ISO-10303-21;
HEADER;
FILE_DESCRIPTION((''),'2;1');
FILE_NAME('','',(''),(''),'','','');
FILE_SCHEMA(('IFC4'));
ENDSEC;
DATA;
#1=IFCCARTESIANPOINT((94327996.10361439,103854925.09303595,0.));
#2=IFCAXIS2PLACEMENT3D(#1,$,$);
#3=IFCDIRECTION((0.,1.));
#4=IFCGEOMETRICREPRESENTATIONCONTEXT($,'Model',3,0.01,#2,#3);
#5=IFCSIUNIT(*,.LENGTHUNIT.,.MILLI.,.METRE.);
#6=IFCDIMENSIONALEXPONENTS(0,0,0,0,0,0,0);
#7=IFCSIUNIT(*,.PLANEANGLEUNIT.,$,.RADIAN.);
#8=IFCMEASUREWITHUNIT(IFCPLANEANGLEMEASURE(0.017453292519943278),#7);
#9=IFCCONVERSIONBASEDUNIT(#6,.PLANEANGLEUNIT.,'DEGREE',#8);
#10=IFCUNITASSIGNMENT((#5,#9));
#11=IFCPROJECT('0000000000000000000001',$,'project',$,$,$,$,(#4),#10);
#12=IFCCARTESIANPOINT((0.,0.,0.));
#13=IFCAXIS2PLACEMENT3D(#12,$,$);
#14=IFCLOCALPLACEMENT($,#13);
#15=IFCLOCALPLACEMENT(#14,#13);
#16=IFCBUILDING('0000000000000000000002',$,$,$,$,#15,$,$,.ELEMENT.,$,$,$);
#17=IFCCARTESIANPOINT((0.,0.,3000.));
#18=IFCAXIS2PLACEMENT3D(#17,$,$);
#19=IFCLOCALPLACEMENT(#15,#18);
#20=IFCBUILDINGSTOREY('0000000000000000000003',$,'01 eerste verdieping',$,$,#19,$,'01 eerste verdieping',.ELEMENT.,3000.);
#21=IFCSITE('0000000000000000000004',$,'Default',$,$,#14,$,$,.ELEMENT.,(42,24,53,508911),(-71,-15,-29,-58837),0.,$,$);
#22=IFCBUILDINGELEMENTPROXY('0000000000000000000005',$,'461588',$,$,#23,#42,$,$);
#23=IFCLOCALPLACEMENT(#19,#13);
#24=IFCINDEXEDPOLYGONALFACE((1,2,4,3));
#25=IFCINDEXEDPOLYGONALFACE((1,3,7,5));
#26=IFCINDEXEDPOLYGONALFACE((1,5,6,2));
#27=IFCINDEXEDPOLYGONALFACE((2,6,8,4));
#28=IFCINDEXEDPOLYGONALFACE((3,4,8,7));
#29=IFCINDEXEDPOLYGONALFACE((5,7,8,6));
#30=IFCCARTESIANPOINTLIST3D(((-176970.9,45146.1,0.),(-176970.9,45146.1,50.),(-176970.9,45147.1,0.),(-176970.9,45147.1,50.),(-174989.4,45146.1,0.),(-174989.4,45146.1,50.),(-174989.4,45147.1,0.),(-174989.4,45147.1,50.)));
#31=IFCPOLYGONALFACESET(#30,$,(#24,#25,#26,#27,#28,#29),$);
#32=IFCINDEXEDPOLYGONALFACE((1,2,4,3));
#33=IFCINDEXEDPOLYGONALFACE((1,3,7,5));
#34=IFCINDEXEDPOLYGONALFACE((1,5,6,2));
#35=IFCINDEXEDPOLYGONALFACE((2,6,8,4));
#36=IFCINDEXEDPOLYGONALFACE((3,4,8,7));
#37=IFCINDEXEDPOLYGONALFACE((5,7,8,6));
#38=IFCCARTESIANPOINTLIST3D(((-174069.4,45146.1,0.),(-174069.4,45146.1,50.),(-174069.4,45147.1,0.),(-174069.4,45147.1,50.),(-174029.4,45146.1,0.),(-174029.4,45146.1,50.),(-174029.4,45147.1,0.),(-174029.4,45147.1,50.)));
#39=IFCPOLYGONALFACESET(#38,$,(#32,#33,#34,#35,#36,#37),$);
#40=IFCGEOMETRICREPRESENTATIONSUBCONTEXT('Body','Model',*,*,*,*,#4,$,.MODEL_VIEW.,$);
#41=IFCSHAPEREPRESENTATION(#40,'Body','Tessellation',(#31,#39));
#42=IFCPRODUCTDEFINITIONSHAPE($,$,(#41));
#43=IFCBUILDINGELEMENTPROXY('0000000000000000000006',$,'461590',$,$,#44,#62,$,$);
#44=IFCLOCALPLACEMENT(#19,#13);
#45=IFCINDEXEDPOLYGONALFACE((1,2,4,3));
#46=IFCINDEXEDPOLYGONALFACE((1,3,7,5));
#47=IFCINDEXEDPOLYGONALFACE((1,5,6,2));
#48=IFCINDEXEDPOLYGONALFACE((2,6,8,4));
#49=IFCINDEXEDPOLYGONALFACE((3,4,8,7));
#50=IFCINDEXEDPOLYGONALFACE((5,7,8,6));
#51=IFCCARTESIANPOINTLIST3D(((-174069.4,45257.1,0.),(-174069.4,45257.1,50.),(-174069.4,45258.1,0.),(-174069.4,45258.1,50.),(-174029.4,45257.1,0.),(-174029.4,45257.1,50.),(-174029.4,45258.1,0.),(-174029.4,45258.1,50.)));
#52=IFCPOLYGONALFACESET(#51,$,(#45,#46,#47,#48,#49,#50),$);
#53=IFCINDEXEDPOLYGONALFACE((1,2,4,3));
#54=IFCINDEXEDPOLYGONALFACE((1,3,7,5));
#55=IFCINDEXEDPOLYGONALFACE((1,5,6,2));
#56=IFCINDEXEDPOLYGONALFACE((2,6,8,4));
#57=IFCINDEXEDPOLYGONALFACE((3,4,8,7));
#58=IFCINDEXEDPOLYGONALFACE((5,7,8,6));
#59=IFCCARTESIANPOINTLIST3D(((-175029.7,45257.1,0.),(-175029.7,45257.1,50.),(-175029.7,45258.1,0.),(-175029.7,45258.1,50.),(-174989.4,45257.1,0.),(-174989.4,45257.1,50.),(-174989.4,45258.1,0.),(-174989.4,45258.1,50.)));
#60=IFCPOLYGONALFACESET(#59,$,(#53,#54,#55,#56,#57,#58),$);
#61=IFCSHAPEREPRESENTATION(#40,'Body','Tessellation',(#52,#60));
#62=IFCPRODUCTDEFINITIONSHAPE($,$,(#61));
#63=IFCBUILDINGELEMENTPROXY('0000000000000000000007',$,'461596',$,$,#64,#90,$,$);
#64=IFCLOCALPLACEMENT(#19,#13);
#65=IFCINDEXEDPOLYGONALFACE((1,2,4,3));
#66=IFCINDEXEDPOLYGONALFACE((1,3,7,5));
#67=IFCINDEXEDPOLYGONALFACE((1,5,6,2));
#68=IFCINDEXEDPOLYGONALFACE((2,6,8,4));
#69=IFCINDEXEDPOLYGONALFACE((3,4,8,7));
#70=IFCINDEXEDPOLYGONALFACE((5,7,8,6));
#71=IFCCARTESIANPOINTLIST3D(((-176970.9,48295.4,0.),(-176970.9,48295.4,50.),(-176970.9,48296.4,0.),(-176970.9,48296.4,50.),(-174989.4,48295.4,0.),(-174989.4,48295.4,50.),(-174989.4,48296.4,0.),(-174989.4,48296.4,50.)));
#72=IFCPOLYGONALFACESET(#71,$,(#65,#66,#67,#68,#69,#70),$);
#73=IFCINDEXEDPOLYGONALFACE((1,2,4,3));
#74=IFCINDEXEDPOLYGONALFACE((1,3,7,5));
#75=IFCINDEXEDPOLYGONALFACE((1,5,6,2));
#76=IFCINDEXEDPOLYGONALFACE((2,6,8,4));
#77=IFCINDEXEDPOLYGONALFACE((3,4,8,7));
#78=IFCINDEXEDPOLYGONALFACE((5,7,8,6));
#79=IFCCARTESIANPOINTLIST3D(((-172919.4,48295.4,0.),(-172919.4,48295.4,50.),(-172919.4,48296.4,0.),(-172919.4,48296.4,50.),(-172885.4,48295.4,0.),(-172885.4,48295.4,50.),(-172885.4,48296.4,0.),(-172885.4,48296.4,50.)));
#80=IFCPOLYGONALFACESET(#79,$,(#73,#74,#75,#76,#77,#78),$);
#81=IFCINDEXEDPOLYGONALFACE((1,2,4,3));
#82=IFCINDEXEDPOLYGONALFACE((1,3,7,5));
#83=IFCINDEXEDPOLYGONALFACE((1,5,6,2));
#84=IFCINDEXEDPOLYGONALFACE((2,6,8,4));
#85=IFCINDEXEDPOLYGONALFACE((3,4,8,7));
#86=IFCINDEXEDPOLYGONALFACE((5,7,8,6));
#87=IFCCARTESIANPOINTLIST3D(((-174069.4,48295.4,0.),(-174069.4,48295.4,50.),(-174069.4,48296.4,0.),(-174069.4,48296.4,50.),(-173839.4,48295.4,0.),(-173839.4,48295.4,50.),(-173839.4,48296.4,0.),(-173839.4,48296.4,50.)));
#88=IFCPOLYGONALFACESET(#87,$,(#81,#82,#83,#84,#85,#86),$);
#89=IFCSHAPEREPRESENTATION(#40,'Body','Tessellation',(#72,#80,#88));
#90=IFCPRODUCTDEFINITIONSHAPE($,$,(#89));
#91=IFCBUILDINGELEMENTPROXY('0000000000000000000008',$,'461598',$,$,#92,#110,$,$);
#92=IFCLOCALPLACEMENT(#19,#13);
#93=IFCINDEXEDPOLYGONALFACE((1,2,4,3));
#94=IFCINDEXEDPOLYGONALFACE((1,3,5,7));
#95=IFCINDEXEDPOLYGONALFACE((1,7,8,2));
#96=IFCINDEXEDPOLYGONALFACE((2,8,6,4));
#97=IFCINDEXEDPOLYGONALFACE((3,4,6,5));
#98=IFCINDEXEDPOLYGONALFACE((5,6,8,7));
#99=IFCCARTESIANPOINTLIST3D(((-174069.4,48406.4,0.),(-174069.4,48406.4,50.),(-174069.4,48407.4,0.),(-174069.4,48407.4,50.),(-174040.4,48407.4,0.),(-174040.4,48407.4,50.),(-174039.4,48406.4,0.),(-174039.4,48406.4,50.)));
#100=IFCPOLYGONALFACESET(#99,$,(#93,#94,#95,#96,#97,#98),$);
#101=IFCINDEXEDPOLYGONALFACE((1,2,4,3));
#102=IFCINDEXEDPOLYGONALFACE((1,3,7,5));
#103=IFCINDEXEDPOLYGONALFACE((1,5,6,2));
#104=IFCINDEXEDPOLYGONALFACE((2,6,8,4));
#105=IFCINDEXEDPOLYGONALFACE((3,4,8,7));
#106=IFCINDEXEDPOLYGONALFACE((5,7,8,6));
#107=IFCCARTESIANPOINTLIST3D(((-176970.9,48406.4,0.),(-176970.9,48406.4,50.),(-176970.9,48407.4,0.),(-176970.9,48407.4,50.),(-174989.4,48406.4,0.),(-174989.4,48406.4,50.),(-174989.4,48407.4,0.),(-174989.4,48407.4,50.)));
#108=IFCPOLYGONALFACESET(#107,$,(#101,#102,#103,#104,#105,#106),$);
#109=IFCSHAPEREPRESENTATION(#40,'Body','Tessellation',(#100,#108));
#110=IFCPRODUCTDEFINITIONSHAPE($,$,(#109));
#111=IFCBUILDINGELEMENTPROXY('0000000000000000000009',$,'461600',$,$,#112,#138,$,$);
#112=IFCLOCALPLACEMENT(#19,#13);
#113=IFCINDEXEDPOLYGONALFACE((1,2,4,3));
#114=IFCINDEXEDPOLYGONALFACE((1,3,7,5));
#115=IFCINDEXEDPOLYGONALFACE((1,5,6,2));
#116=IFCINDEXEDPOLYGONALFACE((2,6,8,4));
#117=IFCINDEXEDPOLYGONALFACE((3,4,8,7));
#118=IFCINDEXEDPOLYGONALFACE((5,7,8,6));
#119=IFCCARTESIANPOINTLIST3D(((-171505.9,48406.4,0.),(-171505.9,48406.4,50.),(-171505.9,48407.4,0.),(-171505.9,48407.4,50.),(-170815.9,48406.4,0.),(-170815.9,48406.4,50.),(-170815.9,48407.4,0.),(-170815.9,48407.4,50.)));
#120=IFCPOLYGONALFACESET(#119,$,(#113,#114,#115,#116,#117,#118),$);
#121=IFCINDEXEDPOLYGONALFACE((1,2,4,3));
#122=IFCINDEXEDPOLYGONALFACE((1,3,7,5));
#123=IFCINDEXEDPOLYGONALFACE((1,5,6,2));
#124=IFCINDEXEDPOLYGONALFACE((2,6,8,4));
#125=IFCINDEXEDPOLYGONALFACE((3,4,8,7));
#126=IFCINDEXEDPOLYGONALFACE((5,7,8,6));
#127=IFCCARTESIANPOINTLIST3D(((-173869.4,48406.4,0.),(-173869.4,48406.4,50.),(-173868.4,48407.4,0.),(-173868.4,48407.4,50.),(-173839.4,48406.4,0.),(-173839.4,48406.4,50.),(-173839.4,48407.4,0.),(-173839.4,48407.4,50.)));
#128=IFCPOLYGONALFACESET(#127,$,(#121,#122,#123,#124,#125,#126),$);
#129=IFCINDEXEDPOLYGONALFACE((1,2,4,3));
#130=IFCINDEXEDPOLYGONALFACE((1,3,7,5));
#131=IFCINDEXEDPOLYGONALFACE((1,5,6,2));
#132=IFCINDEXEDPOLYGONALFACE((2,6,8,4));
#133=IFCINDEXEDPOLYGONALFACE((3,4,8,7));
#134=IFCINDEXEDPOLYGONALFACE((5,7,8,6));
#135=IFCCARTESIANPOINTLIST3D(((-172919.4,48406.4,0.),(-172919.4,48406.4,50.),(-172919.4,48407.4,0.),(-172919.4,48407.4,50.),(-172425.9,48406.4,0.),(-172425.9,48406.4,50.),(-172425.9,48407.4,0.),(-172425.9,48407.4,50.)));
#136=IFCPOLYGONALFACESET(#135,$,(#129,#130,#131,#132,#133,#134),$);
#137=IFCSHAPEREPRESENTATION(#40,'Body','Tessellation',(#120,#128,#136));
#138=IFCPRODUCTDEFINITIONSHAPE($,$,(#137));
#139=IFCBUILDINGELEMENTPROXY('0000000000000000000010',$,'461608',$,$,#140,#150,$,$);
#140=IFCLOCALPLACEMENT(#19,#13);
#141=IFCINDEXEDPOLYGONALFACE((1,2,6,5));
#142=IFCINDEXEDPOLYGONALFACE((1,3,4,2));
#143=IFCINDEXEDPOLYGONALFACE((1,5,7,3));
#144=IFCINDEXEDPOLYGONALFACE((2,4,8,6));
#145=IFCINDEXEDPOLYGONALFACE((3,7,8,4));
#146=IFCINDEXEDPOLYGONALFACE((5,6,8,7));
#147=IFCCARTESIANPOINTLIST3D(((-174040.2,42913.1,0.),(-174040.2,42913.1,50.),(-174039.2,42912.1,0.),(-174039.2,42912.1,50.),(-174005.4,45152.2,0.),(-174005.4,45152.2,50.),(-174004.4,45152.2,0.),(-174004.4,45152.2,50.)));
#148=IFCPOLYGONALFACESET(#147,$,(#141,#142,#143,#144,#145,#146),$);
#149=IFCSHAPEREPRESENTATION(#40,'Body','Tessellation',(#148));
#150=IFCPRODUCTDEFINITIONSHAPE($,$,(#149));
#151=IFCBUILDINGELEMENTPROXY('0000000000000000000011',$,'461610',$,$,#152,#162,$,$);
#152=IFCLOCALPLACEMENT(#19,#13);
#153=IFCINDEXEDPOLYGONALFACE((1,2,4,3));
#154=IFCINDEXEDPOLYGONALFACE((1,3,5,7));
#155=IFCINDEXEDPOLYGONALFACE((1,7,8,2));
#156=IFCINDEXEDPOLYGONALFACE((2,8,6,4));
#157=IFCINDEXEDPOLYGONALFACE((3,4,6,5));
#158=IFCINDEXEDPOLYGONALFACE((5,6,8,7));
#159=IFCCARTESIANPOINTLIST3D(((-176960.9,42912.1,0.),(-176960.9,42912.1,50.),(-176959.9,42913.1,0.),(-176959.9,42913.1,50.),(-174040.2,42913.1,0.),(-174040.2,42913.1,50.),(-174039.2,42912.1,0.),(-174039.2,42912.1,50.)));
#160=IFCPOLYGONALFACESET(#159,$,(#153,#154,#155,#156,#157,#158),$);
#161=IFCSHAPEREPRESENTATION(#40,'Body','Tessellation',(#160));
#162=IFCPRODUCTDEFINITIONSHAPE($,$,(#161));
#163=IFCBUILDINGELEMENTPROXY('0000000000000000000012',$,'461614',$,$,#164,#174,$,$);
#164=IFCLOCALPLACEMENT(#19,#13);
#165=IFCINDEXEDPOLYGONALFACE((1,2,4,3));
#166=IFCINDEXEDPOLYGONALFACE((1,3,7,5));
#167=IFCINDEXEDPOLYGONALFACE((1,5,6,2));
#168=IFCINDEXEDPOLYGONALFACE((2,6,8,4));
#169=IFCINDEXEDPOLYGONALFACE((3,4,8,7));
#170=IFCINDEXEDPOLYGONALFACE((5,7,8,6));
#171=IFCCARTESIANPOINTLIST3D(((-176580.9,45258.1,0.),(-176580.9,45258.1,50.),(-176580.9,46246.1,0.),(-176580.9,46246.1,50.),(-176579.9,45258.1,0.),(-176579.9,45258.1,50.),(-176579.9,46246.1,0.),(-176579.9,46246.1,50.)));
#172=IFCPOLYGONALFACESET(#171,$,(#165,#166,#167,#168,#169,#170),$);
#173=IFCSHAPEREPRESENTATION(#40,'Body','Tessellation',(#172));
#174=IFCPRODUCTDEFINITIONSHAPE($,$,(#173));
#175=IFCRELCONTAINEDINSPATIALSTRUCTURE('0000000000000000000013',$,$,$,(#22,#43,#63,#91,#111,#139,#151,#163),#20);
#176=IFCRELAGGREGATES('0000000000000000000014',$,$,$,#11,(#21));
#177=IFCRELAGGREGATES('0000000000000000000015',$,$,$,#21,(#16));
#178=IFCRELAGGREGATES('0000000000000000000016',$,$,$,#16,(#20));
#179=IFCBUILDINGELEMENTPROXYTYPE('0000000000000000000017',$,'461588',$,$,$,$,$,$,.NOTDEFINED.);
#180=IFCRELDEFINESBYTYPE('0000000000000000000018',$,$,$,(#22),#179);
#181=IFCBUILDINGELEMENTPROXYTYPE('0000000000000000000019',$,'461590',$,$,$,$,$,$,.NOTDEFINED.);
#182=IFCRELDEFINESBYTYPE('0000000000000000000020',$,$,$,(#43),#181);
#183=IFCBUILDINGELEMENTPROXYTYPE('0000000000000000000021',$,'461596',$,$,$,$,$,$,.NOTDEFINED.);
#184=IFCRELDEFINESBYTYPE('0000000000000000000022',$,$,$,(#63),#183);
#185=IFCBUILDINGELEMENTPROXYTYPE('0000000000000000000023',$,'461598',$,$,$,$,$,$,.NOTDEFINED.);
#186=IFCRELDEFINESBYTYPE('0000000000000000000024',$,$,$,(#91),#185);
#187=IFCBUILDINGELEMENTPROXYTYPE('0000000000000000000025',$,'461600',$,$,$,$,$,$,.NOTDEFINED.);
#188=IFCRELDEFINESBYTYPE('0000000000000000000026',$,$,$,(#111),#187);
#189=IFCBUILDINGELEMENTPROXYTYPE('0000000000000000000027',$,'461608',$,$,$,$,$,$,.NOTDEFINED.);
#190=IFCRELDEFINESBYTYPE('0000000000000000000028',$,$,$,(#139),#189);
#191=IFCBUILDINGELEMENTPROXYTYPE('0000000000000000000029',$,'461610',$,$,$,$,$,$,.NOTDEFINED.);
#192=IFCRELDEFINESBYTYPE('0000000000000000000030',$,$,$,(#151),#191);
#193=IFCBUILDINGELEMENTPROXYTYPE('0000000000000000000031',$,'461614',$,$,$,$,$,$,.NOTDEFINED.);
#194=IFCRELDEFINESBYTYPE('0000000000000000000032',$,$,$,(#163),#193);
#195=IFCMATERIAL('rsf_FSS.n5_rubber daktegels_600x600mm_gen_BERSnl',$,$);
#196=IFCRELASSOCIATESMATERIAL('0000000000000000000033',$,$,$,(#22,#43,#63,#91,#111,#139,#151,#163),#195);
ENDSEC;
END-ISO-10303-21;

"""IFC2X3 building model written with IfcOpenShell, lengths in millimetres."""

from ifc_helpers import new_model, entity, si_unit, converted_unit, direction, frame, frame_2d, origin, origin_2d_with_axis, place, context, subcontext, project, spatial, polyline, rectangle, outline, extrude, material, type_object, element, save


model = new_model("IFC2X3")

# Units and contexts
model_context = context("Model", 3, precision=0.01, world=frame((94327996.10361439, 103854925.09303595, 0.0)), true_north=direction((0.0, 1.0)))
body_context = subcontext(model_context, "Body", "Model", "MODEL_VIEW")
ifc_project = project(units=[si_unit("LENGTHUNIT", "METRE", prefix="MILLI"), converted_unit("PLANEANGLEUNIT", "DEGREE", entity("IfcPlaneAngleMeasure", 0.017453292519943278), si_unit("PLANEANGLEUNIT", "RADIAN"), dimensions=[0, 0, 0, 0, 0, 0, 0])], contexts=[model_context])

# Site, building, storey
site_placement = place(None, origin())
site = spatial("IfcSite", under=ifc_project, at=site_placement, Name="Default", CompositionType="ELEMENT", RefLatitude=(42, 24, 53, 508911), RefLongitude=(-71, -15, -29, -58837), RefElevation=0.0)
building_placement = place(site_placement, origin())
building = spatial("IfcBuilding", under=site, at=building_placement, CompositionType="ELEMENT")
storey_placement = place(building_placement, frame((0.0, 0.0, 3000.0)))
storey = spatial("IfcBuildingStorey", under=building, at=storey_placement, Name="01 eerste verdieping", LongName="01 eerste verdieping", CompositionType="ELEMENT", Elevation=3000.0)

# Building element proxies
ifc_material = material(Name="rsf_FSS.n5_rubber daktegels_600x600mm_gen_BERSnl")
building_element_proxy_type_1 = type_object("IfcBuildingElementProxyType", Name="461588", PredefinedType="NOTDEFINED")
proxy_1_placement = place(storey_placement, origin())
element("IfcBuildingElementProxy", 1, at=proxy_1_placement, inside=storey, type_object=building_element_proxy_type_1, material=ifc_material, Name="461588", context=body_context, shape_type="SweptSolid", body=[
    extrude(rectangle(XDim=1981.5, YDim=1.0, at=frame_2d((0.0, 0.0), x_axis=(1.0, 0.0))), frame((-175980.1, 45146.6, 0.0)), (0.0, 0.0, 1.0), 50.0),
    extrude(rectangle(XDim=40.0, YDim=1.0, at=frame_2d((0.0, 0.0), x_axis=(1.0, 0.0))), frame((-174049.4, 45146.6, 0.0)), (0.0, 0.0, 1.0), 50.0),
])
building_element_proxy_type_2 = type_object("IfcBuildingElementProxyType", Name="461590", PredefinedType="NOTDEFINED")
proxy_2_placement = place(storey_placement, origin())
element("IfcBuildingElementProxy", 2, at=proxy_2_placement, inside=storey, type_object=building_element_proxy_type_2, material=ifc_material, Name="461590", context=body_context, shape_type="SweptSolid", body=[
    extrude(rectangle(XDim=40.0, YDim=1.0, at=frame_2d((0.0, 0.0), x_axis=(1.0, 0.0))), frame((-174049.4, 45257.6, 0.0), z_axis=(0.0, 0.0, 1.0), x_axis=(-1.0, 0.0, 0.0)), (0.0, 0.0, 1.0), 50.0),
    extrude(rectangle(XDim=40.4, YDim=1.0, at=origin_2d_with_axis()), frame((-175009.6, 45257.6, 0.0), z_axis=(0.0, 0.0, 1.0), x_axis=(-1.0, 0.0, 0.0)), (0.0, 0.0, 1.0), 50.0),
])
building_element_proxy_type_3 = type_object("IfcBuildingElementProxyType", Name="461596", PredefinedType="NOTDEFINED")
proxy_3_placement = place(storey_placement, origin())
element("IfcBuildingElementProxy", 3, at=proxy_3_placement, inside=storey, type_object=building_element_proxy_type_3, material=ifc_material, Name="461596", context=body_context, shape_type="SweptSolid", body=[
    extrude(rectangle(XDim=1981.5, YDim=1.0, at=frame_2d((0.0, 0.0), x_axis=(1.0, 0.0))), frame((-175980.1, 48295.9, 0.0)), (0.0, 0.0, 1.0), 50.0),
    extrude(rectangle(XDim=34.0, YDim=1.0, at=frame_2d((0.0, 0.0), x_axis=(1.0, 0.0))), frame((-172902.4, 48295.9, 0.0)), (0.0, 0.0, 1.0), 50.0),
    extrude(rectangle(XDim=230.0, YDim=1.0, at=frame_2d((0.0, 0.0), x_axis=(1.0, 0.0))), frame((-173954.4, 48295.9, 0.0)), (0.0, 0.0, 1.0), 50.0),
])
building_element_proxy_type_4 = type_object("IfcBuildingElementProxyType", Name="461598", PredefinedType="NOTDEFINED")
proxy_4_placement = place(storey_placement, origin())
element("IfcBuildingElementProxy", 4, at=proxy_4_placement, inside=storey, type_object=building_element_proxy_type_4, material=ifc_material, Name="461598", context=body_context, shape_type="SweptSolid", body=[
    extrude(outline(polyline([(-14.3, -0.5), (14.8, -0.5), (14.8, 0.5), (-15.3, 0.5), (-14.3, -0.5)])), frame((-174054.6, 48406.9, 0.0), z_axis=(0.0, 0.0, 1.0), x_axis=(-1.0, 0.0, 0.0)), (0.0, 0.0, 1.0), 50.0),
    extrude(rectangle(XDim=1981.5, YDim=1.0, at=frame_2d((0.0, 0.0), x_axis=(1.0, 0.0))), frame((-175980.1, 48406.9, 0.0), z_axis=(0.0, 0.0, 1.0), x_axis=(-1.0, 0.0, 0.0)), (0.0, 0.0, 1.0), 50.0),
])
building_element_proxy_type_5 = type_object("IfcBuildingElementProxyType", Name="461600", PredefinedType="NOTDEFINED")
proxy_5_placement = place(storey_placement, origin())
element("IfcBuildingElementProxy", 5, at=proxy_5_placement, inside=storey, type_object=building_element_proxy_type_5, material=ifc_material, Name="461600", context=body_context, shape_type="SweptSolid", body=[
    extrude(rectangle(XDim=690.0, YDim=1.0, at=origin_2d_with_axis()), frame((-171160.9, 48406.9, 0.0), z_axis=(0.0, 0.0, 1.0), x_axis=(-1.0, 0.0, 0.0)), (0.0, 0.0, 1.0), 50.0),
    extrude(outline(polyline([(-14.7, -0.5), (14.2, -0.5), (15.2, 0.5), (-14.7, 0.5), (-14.7, -0.5)])), frame((-173854.1, 48406.9, 0.0), z_axis=(0.0, 0.0, 1.0), x_axis=(-1.0, 0.0, 0.0)), (0.0, 0.0, 1.0), 50.0),
    extrude(rectangle(XDim=493.5, YDim=1.0, at=origin_2d_with_axis()), frame((-172672.6, 48406.9, 0.0), z_axis=(0.0, 0.0, 1.0), x_axis=(-1.0, 0.0, 0.0)), (0.0, 0.0, 1.0), 50.0),
])
building_element_proxy_type_6 = type_object("IfcBuildingElementProxyType", Name="461608", PredefinedType="NOTDEFINED")
proxy_6_placement = place(storey_placement, origin())
element("IfcBuildingElementProxy", 6, at=proxy_6_placement, inside=storey, type_object=building_element_proxy_type_6, material=ifc_material, Name="461608", context=body_context, shape_type="SweptSolid", body=[
    extrude(outline(polyline([(-1120.0, -0.5), (1119.5, -0.5), (1120.5, 0.5), (-1120.0, 0.5), (-1120.0, -0.5)])), frame((-174022.3, 44032.4, 0.0), z_axis=(0.0, 0.0, 1.0), x_axis=(-0.015554, -0.999879, 0.0)), (0.0, 0.0, 1.0), 50.0),
])
building_element_proxy_type_7 = type_object("IfcBuildingElementProxyType", Name="461610", PredefinedType="NOTDEFINED")
proxy_7_placement = place(storey_placement, origin())
element("IfcBuildingElementProxy", 7, at=proxy_7_placement, inside=storey, type_object=building_element_proxy_type_7, material=ifc_material, Name="461610", context=body_context, shape_type="SweptSolid", body=[
    extrude(outline(polyline([(-1459.8, -0.5), (1459.8, -0.5), (1460.8, 0.5), (-1460.8, 0.5), (-1459.8, -0.5)])), frame((-175500.0, 42912.6, 0.0), z_axis=(0.0, 0.0, 1.0), x_axis=(-1.0, 0.0, 0.0)), (0.0, 0.0, 1.0), 50.0),
])
building_element_proxy_type_8 = type_object("IfcBuildingElementProxyType", Name="461614", PredefinedType="NOTDEFINED")
proxy_8_placement = place(storey_placement, origin())
element("IfcBuildingElementProxy", 8, at=proxy_8_placement, inside=storey, type_object=building_element_proxy_type_8, material=ifc_material, Name="461614", context=body_context, shape_type="SweptSolid", body=[
    extrude(rectangle(XDim=988.0, YDim=1.0, at=frame_2d((0.0, 0.0), x_axis=(1.0, 0.0))), frame((-176580.4, 45752.1, 0.0), z_axis=(0.0, 0.0, 1.0), x_axis=(0.0, 1.0, 0.0)), (0.0, 0.0, 1.0), 50.0),
])

save(model, "model.ifc")
